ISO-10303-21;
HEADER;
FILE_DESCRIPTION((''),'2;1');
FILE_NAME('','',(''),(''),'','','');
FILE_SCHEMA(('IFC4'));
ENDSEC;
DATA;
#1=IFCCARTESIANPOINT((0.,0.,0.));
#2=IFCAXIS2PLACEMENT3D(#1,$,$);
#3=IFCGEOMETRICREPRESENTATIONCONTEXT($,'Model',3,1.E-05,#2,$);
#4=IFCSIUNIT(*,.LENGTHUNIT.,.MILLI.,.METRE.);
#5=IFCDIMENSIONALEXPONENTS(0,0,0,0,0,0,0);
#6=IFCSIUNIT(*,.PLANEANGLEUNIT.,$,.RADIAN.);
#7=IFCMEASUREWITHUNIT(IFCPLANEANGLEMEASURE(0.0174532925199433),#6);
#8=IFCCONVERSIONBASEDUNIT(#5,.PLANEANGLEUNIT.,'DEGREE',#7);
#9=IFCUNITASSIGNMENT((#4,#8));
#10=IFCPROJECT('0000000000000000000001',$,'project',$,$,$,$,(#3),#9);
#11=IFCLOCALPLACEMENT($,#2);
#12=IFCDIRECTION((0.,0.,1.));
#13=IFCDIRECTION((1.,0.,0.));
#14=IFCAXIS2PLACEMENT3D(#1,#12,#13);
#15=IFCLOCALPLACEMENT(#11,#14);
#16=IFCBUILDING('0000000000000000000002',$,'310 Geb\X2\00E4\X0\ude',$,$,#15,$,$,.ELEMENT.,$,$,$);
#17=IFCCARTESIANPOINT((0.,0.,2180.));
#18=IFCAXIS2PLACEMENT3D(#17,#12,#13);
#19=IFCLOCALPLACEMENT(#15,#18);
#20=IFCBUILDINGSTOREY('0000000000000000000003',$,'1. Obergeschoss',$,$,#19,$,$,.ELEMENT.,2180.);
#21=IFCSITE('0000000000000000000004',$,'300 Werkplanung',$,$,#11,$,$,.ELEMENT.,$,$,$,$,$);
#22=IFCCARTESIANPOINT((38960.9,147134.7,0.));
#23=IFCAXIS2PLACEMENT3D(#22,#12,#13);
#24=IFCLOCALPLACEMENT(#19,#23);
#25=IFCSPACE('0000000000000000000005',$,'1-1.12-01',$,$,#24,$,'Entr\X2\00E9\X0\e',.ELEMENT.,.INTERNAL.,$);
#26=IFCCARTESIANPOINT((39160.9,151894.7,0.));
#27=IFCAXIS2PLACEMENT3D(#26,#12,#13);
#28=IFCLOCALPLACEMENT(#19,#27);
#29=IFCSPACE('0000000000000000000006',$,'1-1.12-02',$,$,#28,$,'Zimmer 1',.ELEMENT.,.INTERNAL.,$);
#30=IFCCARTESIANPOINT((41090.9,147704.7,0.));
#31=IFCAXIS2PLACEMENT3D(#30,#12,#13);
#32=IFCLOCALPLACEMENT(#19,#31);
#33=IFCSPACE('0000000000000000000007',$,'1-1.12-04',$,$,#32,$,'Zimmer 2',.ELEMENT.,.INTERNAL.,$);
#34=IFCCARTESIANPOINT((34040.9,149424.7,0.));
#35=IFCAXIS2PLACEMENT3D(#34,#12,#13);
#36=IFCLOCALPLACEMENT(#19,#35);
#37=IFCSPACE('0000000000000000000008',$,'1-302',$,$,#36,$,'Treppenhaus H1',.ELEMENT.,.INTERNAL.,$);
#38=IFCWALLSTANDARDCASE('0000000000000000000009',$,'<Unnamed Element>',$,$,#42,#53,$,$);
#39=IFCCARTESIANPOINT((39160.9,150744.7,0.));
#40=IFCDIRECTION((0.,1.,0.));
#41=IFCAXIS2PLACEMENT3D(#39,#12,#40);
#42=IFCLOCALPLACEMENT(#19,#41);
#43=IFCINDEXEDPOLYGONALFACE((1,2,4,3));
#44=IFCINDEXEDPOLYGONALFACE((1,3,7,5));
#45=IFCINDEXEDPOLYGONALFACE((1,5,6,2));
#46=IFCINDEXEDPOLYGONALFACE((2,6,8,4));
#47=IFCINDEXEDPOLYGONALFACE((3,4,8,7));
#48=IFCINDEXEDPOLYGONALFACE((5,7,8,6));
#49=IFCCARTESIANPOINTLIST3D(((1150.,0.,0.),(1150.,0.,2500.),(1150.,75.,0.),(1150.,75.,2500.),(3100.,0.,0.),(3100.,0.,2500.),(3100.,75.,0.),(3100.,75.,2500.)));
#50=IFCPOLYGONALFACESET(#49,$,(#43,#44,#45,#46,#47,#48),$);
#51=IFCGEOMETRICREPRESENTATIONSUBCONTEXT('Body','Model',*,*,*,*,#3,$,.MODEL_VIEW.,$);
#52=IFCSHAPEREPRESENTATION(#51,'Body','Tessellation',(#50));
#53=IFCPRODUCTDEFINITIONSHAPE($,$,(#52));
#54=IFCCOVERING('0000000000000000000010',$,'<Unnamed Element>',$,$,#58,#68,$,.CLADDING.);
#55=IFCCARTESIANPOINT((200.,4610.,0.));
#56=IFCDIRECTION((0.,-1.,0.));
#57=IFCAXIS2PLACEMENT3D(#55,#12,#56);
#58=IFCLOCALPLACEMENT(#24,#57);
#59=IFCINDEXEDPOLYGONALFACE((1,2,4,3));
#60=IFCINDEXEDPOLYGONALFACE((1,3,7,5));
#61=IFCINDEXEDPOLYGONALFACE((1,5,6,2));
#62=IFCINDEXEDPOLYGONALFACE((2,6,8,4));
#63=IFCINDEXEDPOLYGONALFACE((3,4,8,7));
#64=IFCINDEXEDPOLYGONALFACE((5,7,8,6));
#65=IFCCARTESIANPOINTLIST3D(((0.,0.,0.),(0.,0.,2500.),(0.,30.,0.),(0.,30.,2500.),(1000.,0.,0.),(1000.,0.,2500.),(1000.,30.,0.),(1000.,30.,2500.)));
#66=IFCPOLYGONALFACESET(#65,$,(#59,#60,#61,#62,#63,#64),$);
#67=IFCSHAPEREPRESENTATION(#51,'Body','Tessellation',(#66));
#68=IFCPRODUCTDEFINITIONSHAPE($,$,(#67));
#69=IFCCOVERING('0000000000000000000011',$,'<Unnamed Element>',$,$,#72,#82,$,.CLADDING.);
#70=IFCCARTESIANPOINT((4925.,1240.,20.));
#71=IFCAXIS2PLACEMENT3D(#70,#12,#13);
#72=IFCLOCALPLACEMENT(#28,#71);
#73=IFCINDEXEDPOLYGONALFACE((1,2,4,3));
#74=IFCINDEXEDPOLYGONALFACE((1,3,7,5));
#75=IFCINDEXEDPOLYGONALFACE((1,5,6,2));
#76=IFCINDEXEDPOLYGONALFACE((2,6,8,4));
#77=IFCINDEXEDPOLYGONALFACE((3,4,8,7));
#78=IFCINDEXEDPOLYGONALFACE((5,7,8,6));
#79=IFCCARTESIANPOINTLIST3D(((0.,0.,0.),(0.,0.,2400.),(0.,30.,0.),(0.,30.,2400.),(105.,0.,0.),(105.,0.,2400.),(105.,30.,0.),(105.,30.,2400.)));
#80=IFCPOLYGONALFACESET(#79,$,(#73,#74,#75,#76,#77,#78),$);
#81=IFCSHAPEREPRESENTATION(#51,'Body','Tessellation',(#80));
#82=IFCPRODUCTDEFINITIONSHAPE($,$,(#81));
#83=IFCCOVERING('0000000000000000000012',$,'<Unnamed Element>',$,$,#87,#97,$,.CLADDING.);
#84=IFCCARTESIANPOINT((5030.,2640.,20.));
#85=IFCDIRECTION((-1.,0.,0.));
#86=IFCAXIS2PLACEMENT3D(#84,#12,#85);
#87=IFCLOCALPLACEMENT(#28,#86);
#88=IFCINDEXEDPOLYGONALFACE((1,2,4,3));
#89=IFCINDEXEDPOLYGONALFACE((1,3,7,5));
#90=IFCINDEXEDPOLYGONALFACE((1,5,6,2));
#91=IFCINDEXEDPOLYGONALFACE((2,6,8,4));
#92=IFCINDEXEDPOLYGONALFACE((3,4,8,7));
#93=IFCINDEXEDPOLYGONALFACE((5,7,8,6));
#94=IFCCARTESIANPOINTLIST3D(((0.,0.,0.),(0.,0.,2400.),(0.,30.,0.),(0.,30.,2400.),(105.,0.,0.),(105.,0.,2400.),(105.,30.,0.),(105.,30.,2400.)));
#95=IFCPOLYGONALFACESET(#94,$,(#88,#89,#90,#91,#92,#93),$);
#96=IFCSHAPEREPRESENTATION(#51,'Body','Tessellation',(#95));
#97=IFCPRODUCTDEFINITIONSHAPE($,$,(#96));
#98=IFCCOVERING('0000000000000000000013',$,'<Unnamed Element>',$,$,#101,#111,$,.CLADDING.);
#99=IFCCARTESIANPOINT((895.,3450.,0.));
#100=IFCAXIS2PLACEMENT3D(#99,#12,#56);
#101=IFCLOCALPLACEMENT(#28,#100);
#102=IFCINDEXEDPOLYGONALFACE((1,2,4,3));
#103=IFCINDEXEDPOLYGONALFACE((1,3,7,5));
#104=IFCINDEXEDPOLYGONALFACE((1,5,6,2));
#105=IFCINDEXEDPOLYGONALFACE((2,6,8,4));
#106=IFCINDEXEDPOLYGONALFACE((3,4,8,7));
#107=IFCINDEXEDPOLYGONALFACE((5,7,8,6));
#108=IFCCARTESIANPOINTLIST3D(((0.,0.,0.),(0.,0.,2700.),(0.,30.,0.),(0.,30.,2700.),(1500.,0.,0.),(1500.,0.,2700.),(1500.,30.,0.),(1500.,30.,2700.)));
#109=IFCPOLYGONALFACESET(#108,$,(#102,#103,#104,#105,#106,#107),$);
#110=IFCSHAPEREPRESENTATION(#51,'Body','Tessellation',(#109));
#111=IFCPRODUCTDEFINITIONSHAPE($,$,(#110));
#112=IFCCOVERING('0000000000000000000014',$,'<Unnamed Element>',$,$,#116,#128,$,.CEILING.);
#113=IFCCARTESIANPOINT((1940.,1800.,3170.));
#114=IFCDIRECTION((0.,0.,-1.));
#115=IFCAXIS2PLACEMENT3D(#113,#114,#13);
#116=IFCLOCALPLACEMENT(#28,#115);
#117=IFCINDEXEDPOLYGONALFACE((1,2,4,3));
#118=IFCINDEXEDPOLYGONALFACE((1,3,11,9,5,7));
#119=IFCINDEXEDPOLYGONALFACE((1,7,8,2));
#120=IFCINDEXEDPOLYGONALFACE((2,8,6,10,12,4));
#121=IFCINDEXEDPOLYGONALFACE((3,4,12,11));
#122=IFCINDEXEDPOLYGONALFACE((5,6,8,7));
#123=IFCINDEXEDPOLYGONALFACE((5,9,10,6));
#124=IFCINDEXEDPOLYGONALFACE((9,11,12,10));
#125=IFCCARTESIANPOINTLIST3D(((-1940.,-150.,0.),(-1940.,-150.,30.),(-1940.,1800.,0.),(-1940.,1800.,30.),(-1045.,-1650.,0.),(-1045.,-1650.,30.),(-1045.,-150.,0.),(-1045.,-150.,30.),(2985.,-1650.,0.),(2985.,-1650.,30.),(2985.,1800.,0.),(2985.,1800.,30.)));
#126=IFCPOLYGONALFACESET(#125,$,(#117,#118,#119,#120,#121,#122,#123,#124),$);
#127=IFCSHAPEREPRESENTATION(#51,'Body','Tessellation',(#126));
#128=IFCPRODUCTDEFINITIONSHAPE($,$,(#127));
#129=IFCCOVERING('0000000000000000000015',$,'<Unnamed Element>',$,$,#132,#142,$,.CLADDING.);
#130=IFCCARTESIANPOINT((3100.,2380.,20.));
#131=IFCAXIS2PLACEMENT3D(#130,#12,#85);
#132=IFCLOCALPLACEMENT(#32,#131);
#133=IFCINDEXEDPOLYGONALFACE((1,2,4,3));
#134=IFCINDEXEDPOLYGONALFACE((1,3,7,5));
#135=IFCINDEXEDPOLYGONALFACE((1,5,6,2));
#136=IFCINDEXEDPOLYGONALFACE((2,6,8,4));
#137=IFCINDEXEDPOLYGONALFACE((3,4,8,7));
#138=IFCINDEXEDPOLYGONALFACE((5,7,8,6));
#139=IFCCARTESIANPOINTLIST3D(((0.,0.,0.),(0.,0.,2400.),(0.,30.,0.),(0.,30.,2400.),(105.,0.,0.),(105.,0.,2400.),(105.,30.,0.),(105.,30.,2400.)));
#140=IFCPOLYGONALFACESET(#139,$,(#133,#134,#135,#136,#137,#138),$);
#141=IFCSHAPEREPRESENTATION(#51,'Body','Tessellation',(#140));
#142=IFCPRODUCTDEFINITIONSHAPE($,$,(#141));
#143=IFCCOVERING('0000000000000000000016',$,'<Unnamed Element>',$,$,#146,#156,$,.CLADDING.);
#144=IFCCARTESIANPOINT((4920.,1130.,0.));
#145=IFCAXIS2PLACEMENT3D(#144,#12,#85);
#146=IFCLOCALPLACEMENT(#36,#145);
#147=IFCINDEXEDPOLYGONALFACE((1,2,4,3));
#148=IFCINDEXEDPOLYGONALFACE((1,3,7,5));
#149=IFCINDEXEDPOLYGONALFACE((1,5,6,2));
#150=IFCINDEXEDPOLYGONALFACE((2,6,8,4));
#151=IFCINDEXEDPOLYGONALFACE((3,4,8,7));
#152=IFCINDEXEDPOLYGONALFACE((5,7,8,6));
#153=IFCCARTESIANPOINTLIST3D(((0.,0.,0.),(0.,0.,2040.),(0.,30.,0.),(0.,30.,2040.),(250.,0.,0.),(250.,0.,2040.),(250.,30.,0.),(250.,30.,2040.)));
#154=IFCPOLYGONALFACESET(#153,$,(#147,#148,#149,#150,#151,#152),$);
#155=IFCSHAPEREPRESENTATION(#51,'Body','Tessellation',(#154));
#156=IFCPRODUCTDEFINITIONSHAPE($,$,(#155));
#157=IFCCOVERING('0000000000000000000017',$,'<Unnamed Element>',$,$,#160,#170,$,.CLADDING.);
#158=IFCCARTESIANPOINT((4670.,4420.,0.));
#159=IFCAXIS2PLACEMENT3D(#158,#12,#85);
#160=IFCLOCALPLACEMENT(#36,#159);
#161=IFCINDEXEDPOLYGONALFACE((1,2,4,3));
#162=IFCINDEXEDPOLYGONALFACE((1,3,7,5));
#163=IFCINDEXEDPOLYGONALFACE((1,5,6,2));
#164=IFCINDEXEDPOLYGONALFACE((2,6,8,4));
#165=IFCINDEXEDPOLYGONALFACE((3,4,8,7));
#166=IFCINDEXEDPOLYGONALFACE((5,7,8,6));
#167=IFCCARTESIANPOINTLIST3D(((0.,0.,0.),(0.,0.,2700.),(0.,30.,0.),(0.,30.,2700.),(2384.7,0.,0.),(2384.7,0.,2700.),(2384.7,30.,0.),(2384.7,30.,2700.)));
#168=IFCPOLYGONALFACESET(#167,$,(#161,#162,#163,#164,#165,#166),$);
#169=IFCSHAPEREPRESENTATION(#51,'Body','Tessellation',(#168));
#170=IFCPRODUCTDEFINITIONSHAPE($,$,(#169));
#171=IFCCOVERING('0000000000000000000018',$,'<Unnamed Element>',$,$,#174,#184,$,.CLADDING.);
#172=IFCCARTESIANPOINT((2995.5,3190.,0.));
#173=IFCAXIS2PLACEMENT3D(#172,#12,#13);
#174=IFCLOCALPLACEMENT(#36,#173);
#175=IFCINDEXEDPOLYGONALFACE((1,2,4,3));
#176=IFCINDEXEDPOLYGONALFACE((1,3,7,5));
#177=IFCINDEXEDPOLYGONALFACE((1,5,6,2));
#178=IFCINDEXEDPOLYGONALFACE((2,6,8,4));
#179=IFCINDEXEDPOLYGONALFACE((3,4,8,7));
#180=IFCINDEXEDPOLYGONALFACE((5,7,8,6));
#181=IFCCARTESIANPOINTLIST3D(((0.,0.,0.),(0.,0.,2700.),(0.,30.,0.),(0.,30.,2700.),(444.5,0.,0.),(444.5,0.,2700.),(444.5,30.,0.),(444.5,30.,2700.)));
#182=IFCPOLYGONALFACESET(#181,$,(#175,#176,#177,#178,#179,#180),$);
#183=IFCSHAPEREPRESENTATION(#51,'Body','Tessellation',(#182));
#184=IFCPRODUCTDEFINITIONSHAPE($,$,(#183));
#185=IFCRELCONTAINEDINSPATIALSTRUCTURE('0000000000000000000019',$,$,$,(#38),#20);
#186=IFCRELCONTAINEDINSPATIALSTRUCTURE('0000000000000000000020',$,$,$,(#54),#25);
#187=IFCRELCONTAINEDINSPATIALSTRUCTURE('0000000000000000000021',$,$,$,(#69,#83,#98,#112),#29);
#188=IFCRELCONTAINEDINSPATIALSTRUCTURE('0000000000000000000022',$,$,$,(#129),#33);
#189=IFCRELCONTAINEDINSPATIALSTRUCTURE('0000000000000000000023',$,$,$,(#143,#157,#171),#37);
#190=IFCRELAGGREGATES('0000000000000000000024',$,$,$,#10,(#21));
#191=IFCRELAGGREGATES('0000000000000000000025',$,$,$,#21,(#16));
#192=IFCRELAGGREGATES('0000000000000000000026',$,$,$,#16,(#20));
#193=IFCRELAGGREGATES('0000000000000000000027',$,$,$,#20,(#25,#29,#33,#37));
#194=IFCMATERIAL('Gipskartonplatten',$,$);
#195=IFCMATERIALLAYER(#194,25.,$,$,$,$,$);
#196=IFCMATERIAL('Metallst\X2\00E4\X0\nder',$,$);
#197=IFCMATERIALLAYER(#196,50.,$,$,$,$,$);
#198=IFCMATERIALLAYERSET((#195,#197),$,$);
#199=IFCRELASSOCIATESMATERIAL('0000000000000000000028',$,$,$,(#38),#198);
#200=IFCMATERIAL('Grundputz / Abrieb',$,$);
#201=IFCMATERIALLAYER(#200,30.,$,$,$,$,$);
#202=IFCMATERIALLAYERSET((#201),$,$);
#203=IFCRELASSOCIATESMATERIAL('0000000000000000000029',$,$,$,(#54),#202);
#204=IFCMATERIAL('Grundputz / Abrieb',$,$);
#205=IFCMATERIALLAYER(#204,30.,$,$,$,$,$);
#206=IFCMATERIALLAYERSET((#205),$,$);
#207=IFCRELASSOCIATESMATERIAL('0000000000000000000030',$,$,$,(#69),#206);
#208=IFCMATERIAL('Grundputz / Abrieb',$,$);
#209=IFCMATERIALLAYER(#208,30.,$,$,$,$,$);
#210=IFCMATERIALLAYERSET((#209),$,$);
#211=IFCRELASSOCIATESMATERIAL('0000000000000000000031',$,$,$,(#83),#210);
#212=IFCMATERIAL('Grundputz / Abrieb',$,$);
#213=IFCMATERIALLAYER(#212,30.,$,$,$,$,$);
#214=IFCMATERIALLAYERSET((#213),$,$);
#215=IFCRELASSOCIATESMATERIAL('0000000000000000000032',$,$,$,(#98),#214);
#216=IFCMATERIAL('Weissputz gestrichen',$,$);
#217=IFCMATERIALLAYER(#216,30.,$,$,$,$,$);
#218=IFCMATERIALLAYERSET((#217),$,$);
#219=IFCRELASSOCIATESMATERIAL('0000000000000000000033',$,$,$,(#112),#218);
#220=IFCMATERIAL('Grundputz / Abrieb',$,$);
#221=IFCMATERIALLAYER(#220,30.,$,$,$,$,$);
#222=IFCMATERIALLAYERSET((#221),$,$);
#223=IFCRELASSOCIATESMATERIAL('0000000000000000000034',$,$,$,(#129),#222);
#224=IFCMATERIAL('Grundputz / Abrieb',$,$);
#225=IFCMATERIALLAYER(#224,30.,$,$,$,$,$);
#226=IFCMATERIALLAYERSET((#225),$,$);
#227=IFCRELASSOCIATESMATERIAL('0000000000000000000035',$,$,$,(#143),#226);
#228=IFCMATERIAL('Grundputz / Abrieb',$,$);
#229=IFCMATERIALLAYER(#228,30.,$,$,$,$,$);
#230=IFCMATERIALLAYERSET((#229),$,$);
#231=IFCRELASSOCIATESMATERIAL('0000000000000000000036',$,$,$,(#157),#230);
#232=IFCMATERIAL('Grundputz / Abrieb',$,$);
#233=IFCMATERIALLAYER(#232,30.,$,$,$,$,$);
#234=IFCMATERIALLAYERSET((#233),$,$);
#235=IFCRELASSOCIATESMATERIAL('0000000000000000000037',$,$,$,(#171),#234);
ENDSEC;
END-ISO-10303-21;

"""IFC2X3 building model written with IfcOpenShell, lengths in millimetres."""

from ifc_helpers import new_model, entity, si_unit, converted_unit, frame, frame_2d, origin, origin_with_axes, place, context, subcontext, project, spatial, polyline, rectangle, outline, extrude, material, layer, layer_set, layer_usage, element, save


model = new_model("IFC2X3")

# Units and contexts
model_context = context("Model", 3, precision=1e-05, world=origin())
body_context = subcontext(model_context, "Body", "Model", "MODEL_VIEW")
ifc_project = project(units=[si_unit("LENGTHUNIT", "METRE", prefix="MILLI"), converted_unit("PLANEANGLEUNIT", "DEGREE", entity("IfcPlaneAngleMeasure", 0.0174532925199433), si_unit("PLANEANGLEUNIT", "RADIAN"), dimensions=[0, 0, 0, 0, 0, 0, 0])], contexts=[model_context])

# Site, building, storey
site_placement = place(None, origin())
site = spatial("IfcSite", under=ifc_project, at=site_placement, Name="300 Werkplanung", CompositionType="ELEMENT")
building_placement = place(site_placement, origin_with_axes())
building = spatial("IfcBuilding", under=site, at=building_placement, Name="310 Gebäude", CompositionType="ELEMENT")
storey_placement = place(building_placement, frame((0.0, 0.0, 2180.0), z_axis=(0.0, 0.0, 1.0), x_axis=(1.0, 0.0, 0.0)))
storey = spatial("IfcBuildingStorey", under=building, at=storey_placement, Name="1. Obergeschoss", CompositionType="ELEMENT", Elevation=2180.0)

# Wall
ifc_material_1 = material(Name="Gipskartonplatten")
ifc_layer_1 = layer(ifc_material_1, 25.0)
ifc_material_2 = material(Name="Metallständer")
ifc_layer_2 = layer(ifc_material_2, 50.0)
ifc_layer_set_1 = layer_set([ifc_layer_1, ifc_layer_2])
ifc_layer_usage_1 = layer_usage(ifc_layer_set_1, "AXIS2", "POSITIVE", 0.0)
wall_1_placement = place(storey_placement, frame((39160.9, 150744.7, 0.0), z_axis=(0.0, 0.0, 1.0), x_axis=(0.0, 1.0, 0.0)))
element("IfcWallStandardCase", 1, at=wall_1_placement, inside=storey, material=ifc_layer_usage_1, Name="<Unnamed Element>", context=body_context, shape_type="SweptSolid", body=[
    extrude(outline(polyline([(1150.0, 0.0), (3100.0, 0.0), (3100.0, 75.0), (1150.0, 75.0), (1150.0, 0.0)])), origin_with_axes(), (0.0, 0.0, 1.0), 2500.0),
])

# Shared definitions
space_1_placement = place(storey_placement, frame((38960.9, 147134.7, 0.0), z_axis=(0.0, 0.0, 1.0), x_axis=(1.0, 0.0, 0.0)))
space_1 = spatial("IfcSpace", under=storey, at=space_1_placement, Name="1-1.12-01", LongName="Entrée", CompositionType="ELEMENT", InteriorOrExteriorSpace="INTERNAL")

# Covering
ifc_material_3 = material(Name="Grundputz / Abrieb")
ifc_layer_3 = layer(ifc_material_3, 30.0)
ifc_layer_set_2 = layer_set([ifc_layer_3])
ifc_layer_usage_2 = layer_usage(ifc_layer_set_2, "AXIS3", "POSITIVE", 0.0)
covering_1_placement = place(space_1_placement, frame((200.0, 4610.0, 0.0), z_axis=(0.0, 0.0, 1.0), x_axis=(0.0, -1.0, 0.0)))
element("IfcCovering", 2, at=covering_1_placement, inside=space_1, material=ifc_layer_usage_2, Name="<Unnamed Element>", PredefinedType="CLADDING", context=body_context, shape_type="SweptSolid", body=[
    extrude(rectangle(XDim=2500.0, YDim=1000.0, at=frame_2d((-500.0, 1250.0), x_axis=(0.0, 1.0))), frame((1000.0, 0.0, 2500.0), z_axis=(0.0, 1.0, 0.0), x_axis=(1.0, 0.0, 0.0)), (0.0, 0.0, 1.0), 30.0),
])

# Shared definitions
space_2_placement = place(storey_placement, frame((39160.9, 151894.7, 0.0), z_axis=(0.0, 0.0, 1.0), x_axis=(1.0, 0.0, 0.0)))
space_2 = spatial("IfcSpace", under=storey, at=space_2_placement, Name="1-1.12-02", LongName="Zimmer 1", CompositionType="ELEMENT", InteriorOrExteriorSpace="INTERNAL")

# Coverings
ifc_material_4 = material(Name="Grundputz / Abrieb")
ifc_layer_4 = layer(ifc_material_4, 30.0)
ifc_layer_set_3 = layer_set([ifc_layer_4])
ifc_layer_usage_3 = layer_usage(ifc_layer_set_3, "AXIS3", "POSITIVE", 0.0)
covering_2_placement = place(space_2_placement, frame((4925.0, 1240.0, 20.0), z_axis=(0.0, 0.0, 1.0), x_axis=(1.0, 0.0, 0.0)))
element("IfcCovering", 3, at=covering_2_placement, inside=space_2, material=ifc_layer_usage_3, Name="<Unnamed Element>", PredefinedType="CLADDING", context=body_context, shape_type="SweptSolid", body=[
    extrude(rectangle(XDim=2400.0, YDim=105.0, at=frame_2d((-52.5, 1200.0), x_axis=(0.0, 1.0))), frame((105.0, 0.0, 2400.0), z_axis=(0.0, 1.0, 0.0), x_axis=(1.0, 0.0, 0.0)), (0.0, 0.0, 1.0), 30.0),
])
ifc_material_5 = material(Name="Grundputz / Abrieb")
ifc_layer_5 = layer(ifc_material_5, 30.0)
ifc_layer_set_4 = layer_set([ifc_layer_5])
ifc_layer_usage_4 = layer_usage(ifc_layer_set_4, "AXIS3", "POSITIVE", 0.0)
covering_3_placement = place(space_2_placement, frame((5030.0, 2640.0, 20.0), z_axis=(0.0, 0.0, 1.0), x_axis=(-1.0, 0.0, 0.0)))
element("IfcCovering", 4, at=covering_3_placement, inside=space_2, material=ifc_layer_usage_4, Name="<Unnamed Element>", PredefinedType="CLADDING", context=body_context, shape_type="SweptSolid", body=[
    extrude(rectangle(XDim=2400.0, YDim=105.0, at=frame_2d((-52.5, 1200.0), x_axis=(0.0, 1.0))), frame((105.0, 0.0, 2400.0), z_axis=(0.0, 1.0, 0.0), x_axis=(1.0, 0.0, 0.0)), (0.0, 0.0, 1.0), 30.0),
])
ifc_material_6 = material(Name="Grundputz / Abrieb")
ifc_layer_6 = layer(ifc_material_6, 30.0)
ifc_layer_set_5 = layer_set([ifc_layer_6])
ifc_layer_usage_5 = layer_usage(ifc_layer_set_5, "AXIS3", "POSITIVE", 0.0)
covering_4_placement = place(space_2_placement, frame((895.0, 3450.0, 0.0), z_axis=(0.0, 0.0, 1.0), x_axis=(0.0, -1.0, 0.0)))
element("IfcCovering", 5, at=covering_4_placement, inside=space_2, material=ifc_layer_usage_5, Name="<Unnamed Element>", PredefinedType="CLADDING", context=body_context, shape_type="SweptSolid", body=[
    extrude(rectangle(XDim=2700.0, YDim=1500.0, at=frame_2d((-750.0, 1350.0), x_axis=(0.0, 1.0))), frame((1500.0, 0.0, 2700.0), z_axis=(0.0, 1.0, 0.0), x_axis=(1.0, 0.0, 0.0)), (0.0, 0.0, 1.0), 30.0),
])
ifc_material_7 = material(Name="Weissputz gestrichen")
ifc_layer_7 = layer(ifc_material_7, 30.0)
ifc_layer_set_6 = layer_set([ifc_layer_7])
ifc_layer_usage_6 = layer_usage(ifc_layer_set_6, "AXIS3", "POSITIVE", 0.0)
covering_5_placement = place(space_2_placement, frame((1940.0, 1800.0, 3170.0), z_axis=(0.0, 0.0, -1.0), x_axis=(1.0, 0.0, 0.0)))
element("IfcCovering", 6, at=covering_5_placement, inside=space_2, material=ifc_layer_usage_6, Name="<Unnamed Element>", PredefinedType="CEILING", context=body_context, shape_type="SweptSolid", body=[
    extrude(outline(polyline([(2985.0, -1650.0), (2985.0, 1800.0), (-1940.0, 1800.0), (-1940.0, -150.0), (-1045.0, -150.0), (-1045.0, -1650.0), (2985.0, -1650.0)])), origin_with_axes(), (0.0, 0.0, 1.0), 30.0),
])

# Shared definitions
space_3_placement = place(storey_placement, frame((41090.9, 147704.7, 0.0), z_axis=(0.0, 0.0, 1.0), x_axis=(1.0, 0.0, 0.0)))
space_3 = spatial("IfcSpace", under=storey, at=space_3_placement, Name="1-1.12-04", LongName="Zimmer 2", CompositionType="ELEMENT", InteriorOrExteriorSpace="INTERNAL")

# Covering
ifc_material_8 = material(Name="Grundputz / Abrieb")
ifc_layer_8 = layer(ifc_material_8, 30.0)
ifc_layer_set_7 = layer_set([ifc_layer_8])
ifc_layer_usage_7 = layer_usage(ifc_layer_set_7, "AXIS3", "POSITIVE", 0.0)
covering_6_placement = place(space_3_placement, frame((3100.0, 2380.0, 20.0), z_axis=(0.0, 0.0, 1.0), x_axis=(-1.0, 0.0, 0.0)))
element("IfcCovering", 7, at=covering_6_placement, inside=space_3, material=ifc_layer_usage_7, Name="<Unnamed Element>", PredefinedType="CLADDING", context=body_context, shape_type="SweptSolid", body=[
    extrude(rectangle(XDim=2400.0, YDim=105.0, at=frame_2d((-52.5, 1200.0), x_axis=(0.0, 1.0))), frame((105.0, 0.0, 2400.0), z_axis=(0.0, 1.0, 0.0), x_axis=(1.0, 0.0, 0.0)), (0.0, 0.0, 1.0), 30.0),
])

# Shared definitions
space_4_placement = place(storey_placement, frame((34040.9, 149424.7, 0.0), z_axis=(0.0, 0.0, 1.0), x_axis=(1.0, 0.0, 0.0)))
space_4 = spatial("IfcSpace", under=storey, at=space_4_placement, Name="1-302", LongName="Treppenhaus H1", CompositionType="ELEMENT", InteriorOrExteriorSpace="INTERNAL")

# Coverings
ifc_material_9 = material(Name="Grundputz / Abrieb")
ifc_layer_9 = layer(ifc_material_9, 30.0)
ifc_layer_set_8 = layer_set([ifc_layer_9])
ifc_layer_usage_8 = layer_usage(ifc_layer_set_8, "AXIS3", "POSITIVE", 0.0)
covering_7_placement = place(space_4_placement, frame((4920.0, 1130.0, 0.0), z_axis=(0.0, 0.0, 1.0), x_axis=(-1.0, 0.0, 0.0)))
element("IfcCovering", 8, at=covering_7_placement, inside=space_4, material=ifc_layer_usage_8, Name="<Unnamed Element>", PredefinedType="CLADDING", context=body_context, shape_type="SweptSolid", body=[
    extrude(rectangle(XDim=2040.0, YDim=250.0, at=frame_2d((-125.0, 1020.0), x_axis=(0.0, 1.0))), frame((250.0, 0.0, 2040.0), z_axis=(0.0, 1.0, 0.0), x_axis=(1.0, 0.0, 0.0)), (0.0, 0.0, 1.0), 30.0),
])
ifc_material_10 = material(Name="Grundputz / Abrieb")
ifc_layer_10 = layer(ifc_material_10, 30.0)
ifc_layer_set_9 = layer_set([ifc_layer_10])
ifc_layer_usage_9 = layer_usage(ifc_layer_set_9, "AXIS3", "POSITIVE", 0.0)
covering_8_placement = place(space_4_placement, frame((4670.0, 4420.0, 0.0), z_axis=(0.0, 0.0, 1.0), x_axis=(-1.0, 0.0, 0.0)))
element("IfcCovering", 9, at=covering_8_placement, inside=space_4, material=ifc_layer_usage_9, Name="<Unnamed Element>", PredefinedType="CLADDING", context=body_context, shape_type="SweptSolid", body=[
    extrude(rectangle(XDim=2700.0, YDim=2384.7, at=frame_2d((-1192.3, 1350.0), x_axis=(0.0, 1.0))), frame((2384.7, 0.0, 2700.0), z_axis=(0.0, 1.0, 0.0), x_axis=(1.0, 0.0, 0.0)), (0.0, 0.0, 1.0), 30.0),
])
ifc_material_11 = material(Name="Grundputz / Abrieb")
ifc_layer_11 = layer(ifc_material_11, 30.0)
ifc_layer_set_10 = layer_set([ifc_layer_11])
ifc_layer_usage_10 = layer_usage(ifc_layer_set_10, "AXIS3", "POSITIVE", 0.0)
covering_9_placement = place(space_4_placement, frame((2995.5, 3190.0, 0.0), z_axis=(0.0, 0.0, 1.0), x_axis=(1.0, 0.0, 0.0)))
element("IfcCovering", 10, at=covering_9_placement, inside=space_4, material=ifc_layer_usage_10, Name="<Unnamed Element>", PredefinedType="CLADDING", context=body_context, shape_type="SweptSolid", body=[
    extrude(rectangle(XDim=2700.0, YDim=444.5, at=frame_2d((-222.3, 1350.0), x_axis=(0.0, 1.0))), frame((444.5, 0.0, 2700.0), z_axis=(0.0, 1.0, 0.0), x_axis=(1.0, 0.0, 0.0)), (0.0, 0.0, 1.0), 30.0),
])

save(model, "model.ifc")
